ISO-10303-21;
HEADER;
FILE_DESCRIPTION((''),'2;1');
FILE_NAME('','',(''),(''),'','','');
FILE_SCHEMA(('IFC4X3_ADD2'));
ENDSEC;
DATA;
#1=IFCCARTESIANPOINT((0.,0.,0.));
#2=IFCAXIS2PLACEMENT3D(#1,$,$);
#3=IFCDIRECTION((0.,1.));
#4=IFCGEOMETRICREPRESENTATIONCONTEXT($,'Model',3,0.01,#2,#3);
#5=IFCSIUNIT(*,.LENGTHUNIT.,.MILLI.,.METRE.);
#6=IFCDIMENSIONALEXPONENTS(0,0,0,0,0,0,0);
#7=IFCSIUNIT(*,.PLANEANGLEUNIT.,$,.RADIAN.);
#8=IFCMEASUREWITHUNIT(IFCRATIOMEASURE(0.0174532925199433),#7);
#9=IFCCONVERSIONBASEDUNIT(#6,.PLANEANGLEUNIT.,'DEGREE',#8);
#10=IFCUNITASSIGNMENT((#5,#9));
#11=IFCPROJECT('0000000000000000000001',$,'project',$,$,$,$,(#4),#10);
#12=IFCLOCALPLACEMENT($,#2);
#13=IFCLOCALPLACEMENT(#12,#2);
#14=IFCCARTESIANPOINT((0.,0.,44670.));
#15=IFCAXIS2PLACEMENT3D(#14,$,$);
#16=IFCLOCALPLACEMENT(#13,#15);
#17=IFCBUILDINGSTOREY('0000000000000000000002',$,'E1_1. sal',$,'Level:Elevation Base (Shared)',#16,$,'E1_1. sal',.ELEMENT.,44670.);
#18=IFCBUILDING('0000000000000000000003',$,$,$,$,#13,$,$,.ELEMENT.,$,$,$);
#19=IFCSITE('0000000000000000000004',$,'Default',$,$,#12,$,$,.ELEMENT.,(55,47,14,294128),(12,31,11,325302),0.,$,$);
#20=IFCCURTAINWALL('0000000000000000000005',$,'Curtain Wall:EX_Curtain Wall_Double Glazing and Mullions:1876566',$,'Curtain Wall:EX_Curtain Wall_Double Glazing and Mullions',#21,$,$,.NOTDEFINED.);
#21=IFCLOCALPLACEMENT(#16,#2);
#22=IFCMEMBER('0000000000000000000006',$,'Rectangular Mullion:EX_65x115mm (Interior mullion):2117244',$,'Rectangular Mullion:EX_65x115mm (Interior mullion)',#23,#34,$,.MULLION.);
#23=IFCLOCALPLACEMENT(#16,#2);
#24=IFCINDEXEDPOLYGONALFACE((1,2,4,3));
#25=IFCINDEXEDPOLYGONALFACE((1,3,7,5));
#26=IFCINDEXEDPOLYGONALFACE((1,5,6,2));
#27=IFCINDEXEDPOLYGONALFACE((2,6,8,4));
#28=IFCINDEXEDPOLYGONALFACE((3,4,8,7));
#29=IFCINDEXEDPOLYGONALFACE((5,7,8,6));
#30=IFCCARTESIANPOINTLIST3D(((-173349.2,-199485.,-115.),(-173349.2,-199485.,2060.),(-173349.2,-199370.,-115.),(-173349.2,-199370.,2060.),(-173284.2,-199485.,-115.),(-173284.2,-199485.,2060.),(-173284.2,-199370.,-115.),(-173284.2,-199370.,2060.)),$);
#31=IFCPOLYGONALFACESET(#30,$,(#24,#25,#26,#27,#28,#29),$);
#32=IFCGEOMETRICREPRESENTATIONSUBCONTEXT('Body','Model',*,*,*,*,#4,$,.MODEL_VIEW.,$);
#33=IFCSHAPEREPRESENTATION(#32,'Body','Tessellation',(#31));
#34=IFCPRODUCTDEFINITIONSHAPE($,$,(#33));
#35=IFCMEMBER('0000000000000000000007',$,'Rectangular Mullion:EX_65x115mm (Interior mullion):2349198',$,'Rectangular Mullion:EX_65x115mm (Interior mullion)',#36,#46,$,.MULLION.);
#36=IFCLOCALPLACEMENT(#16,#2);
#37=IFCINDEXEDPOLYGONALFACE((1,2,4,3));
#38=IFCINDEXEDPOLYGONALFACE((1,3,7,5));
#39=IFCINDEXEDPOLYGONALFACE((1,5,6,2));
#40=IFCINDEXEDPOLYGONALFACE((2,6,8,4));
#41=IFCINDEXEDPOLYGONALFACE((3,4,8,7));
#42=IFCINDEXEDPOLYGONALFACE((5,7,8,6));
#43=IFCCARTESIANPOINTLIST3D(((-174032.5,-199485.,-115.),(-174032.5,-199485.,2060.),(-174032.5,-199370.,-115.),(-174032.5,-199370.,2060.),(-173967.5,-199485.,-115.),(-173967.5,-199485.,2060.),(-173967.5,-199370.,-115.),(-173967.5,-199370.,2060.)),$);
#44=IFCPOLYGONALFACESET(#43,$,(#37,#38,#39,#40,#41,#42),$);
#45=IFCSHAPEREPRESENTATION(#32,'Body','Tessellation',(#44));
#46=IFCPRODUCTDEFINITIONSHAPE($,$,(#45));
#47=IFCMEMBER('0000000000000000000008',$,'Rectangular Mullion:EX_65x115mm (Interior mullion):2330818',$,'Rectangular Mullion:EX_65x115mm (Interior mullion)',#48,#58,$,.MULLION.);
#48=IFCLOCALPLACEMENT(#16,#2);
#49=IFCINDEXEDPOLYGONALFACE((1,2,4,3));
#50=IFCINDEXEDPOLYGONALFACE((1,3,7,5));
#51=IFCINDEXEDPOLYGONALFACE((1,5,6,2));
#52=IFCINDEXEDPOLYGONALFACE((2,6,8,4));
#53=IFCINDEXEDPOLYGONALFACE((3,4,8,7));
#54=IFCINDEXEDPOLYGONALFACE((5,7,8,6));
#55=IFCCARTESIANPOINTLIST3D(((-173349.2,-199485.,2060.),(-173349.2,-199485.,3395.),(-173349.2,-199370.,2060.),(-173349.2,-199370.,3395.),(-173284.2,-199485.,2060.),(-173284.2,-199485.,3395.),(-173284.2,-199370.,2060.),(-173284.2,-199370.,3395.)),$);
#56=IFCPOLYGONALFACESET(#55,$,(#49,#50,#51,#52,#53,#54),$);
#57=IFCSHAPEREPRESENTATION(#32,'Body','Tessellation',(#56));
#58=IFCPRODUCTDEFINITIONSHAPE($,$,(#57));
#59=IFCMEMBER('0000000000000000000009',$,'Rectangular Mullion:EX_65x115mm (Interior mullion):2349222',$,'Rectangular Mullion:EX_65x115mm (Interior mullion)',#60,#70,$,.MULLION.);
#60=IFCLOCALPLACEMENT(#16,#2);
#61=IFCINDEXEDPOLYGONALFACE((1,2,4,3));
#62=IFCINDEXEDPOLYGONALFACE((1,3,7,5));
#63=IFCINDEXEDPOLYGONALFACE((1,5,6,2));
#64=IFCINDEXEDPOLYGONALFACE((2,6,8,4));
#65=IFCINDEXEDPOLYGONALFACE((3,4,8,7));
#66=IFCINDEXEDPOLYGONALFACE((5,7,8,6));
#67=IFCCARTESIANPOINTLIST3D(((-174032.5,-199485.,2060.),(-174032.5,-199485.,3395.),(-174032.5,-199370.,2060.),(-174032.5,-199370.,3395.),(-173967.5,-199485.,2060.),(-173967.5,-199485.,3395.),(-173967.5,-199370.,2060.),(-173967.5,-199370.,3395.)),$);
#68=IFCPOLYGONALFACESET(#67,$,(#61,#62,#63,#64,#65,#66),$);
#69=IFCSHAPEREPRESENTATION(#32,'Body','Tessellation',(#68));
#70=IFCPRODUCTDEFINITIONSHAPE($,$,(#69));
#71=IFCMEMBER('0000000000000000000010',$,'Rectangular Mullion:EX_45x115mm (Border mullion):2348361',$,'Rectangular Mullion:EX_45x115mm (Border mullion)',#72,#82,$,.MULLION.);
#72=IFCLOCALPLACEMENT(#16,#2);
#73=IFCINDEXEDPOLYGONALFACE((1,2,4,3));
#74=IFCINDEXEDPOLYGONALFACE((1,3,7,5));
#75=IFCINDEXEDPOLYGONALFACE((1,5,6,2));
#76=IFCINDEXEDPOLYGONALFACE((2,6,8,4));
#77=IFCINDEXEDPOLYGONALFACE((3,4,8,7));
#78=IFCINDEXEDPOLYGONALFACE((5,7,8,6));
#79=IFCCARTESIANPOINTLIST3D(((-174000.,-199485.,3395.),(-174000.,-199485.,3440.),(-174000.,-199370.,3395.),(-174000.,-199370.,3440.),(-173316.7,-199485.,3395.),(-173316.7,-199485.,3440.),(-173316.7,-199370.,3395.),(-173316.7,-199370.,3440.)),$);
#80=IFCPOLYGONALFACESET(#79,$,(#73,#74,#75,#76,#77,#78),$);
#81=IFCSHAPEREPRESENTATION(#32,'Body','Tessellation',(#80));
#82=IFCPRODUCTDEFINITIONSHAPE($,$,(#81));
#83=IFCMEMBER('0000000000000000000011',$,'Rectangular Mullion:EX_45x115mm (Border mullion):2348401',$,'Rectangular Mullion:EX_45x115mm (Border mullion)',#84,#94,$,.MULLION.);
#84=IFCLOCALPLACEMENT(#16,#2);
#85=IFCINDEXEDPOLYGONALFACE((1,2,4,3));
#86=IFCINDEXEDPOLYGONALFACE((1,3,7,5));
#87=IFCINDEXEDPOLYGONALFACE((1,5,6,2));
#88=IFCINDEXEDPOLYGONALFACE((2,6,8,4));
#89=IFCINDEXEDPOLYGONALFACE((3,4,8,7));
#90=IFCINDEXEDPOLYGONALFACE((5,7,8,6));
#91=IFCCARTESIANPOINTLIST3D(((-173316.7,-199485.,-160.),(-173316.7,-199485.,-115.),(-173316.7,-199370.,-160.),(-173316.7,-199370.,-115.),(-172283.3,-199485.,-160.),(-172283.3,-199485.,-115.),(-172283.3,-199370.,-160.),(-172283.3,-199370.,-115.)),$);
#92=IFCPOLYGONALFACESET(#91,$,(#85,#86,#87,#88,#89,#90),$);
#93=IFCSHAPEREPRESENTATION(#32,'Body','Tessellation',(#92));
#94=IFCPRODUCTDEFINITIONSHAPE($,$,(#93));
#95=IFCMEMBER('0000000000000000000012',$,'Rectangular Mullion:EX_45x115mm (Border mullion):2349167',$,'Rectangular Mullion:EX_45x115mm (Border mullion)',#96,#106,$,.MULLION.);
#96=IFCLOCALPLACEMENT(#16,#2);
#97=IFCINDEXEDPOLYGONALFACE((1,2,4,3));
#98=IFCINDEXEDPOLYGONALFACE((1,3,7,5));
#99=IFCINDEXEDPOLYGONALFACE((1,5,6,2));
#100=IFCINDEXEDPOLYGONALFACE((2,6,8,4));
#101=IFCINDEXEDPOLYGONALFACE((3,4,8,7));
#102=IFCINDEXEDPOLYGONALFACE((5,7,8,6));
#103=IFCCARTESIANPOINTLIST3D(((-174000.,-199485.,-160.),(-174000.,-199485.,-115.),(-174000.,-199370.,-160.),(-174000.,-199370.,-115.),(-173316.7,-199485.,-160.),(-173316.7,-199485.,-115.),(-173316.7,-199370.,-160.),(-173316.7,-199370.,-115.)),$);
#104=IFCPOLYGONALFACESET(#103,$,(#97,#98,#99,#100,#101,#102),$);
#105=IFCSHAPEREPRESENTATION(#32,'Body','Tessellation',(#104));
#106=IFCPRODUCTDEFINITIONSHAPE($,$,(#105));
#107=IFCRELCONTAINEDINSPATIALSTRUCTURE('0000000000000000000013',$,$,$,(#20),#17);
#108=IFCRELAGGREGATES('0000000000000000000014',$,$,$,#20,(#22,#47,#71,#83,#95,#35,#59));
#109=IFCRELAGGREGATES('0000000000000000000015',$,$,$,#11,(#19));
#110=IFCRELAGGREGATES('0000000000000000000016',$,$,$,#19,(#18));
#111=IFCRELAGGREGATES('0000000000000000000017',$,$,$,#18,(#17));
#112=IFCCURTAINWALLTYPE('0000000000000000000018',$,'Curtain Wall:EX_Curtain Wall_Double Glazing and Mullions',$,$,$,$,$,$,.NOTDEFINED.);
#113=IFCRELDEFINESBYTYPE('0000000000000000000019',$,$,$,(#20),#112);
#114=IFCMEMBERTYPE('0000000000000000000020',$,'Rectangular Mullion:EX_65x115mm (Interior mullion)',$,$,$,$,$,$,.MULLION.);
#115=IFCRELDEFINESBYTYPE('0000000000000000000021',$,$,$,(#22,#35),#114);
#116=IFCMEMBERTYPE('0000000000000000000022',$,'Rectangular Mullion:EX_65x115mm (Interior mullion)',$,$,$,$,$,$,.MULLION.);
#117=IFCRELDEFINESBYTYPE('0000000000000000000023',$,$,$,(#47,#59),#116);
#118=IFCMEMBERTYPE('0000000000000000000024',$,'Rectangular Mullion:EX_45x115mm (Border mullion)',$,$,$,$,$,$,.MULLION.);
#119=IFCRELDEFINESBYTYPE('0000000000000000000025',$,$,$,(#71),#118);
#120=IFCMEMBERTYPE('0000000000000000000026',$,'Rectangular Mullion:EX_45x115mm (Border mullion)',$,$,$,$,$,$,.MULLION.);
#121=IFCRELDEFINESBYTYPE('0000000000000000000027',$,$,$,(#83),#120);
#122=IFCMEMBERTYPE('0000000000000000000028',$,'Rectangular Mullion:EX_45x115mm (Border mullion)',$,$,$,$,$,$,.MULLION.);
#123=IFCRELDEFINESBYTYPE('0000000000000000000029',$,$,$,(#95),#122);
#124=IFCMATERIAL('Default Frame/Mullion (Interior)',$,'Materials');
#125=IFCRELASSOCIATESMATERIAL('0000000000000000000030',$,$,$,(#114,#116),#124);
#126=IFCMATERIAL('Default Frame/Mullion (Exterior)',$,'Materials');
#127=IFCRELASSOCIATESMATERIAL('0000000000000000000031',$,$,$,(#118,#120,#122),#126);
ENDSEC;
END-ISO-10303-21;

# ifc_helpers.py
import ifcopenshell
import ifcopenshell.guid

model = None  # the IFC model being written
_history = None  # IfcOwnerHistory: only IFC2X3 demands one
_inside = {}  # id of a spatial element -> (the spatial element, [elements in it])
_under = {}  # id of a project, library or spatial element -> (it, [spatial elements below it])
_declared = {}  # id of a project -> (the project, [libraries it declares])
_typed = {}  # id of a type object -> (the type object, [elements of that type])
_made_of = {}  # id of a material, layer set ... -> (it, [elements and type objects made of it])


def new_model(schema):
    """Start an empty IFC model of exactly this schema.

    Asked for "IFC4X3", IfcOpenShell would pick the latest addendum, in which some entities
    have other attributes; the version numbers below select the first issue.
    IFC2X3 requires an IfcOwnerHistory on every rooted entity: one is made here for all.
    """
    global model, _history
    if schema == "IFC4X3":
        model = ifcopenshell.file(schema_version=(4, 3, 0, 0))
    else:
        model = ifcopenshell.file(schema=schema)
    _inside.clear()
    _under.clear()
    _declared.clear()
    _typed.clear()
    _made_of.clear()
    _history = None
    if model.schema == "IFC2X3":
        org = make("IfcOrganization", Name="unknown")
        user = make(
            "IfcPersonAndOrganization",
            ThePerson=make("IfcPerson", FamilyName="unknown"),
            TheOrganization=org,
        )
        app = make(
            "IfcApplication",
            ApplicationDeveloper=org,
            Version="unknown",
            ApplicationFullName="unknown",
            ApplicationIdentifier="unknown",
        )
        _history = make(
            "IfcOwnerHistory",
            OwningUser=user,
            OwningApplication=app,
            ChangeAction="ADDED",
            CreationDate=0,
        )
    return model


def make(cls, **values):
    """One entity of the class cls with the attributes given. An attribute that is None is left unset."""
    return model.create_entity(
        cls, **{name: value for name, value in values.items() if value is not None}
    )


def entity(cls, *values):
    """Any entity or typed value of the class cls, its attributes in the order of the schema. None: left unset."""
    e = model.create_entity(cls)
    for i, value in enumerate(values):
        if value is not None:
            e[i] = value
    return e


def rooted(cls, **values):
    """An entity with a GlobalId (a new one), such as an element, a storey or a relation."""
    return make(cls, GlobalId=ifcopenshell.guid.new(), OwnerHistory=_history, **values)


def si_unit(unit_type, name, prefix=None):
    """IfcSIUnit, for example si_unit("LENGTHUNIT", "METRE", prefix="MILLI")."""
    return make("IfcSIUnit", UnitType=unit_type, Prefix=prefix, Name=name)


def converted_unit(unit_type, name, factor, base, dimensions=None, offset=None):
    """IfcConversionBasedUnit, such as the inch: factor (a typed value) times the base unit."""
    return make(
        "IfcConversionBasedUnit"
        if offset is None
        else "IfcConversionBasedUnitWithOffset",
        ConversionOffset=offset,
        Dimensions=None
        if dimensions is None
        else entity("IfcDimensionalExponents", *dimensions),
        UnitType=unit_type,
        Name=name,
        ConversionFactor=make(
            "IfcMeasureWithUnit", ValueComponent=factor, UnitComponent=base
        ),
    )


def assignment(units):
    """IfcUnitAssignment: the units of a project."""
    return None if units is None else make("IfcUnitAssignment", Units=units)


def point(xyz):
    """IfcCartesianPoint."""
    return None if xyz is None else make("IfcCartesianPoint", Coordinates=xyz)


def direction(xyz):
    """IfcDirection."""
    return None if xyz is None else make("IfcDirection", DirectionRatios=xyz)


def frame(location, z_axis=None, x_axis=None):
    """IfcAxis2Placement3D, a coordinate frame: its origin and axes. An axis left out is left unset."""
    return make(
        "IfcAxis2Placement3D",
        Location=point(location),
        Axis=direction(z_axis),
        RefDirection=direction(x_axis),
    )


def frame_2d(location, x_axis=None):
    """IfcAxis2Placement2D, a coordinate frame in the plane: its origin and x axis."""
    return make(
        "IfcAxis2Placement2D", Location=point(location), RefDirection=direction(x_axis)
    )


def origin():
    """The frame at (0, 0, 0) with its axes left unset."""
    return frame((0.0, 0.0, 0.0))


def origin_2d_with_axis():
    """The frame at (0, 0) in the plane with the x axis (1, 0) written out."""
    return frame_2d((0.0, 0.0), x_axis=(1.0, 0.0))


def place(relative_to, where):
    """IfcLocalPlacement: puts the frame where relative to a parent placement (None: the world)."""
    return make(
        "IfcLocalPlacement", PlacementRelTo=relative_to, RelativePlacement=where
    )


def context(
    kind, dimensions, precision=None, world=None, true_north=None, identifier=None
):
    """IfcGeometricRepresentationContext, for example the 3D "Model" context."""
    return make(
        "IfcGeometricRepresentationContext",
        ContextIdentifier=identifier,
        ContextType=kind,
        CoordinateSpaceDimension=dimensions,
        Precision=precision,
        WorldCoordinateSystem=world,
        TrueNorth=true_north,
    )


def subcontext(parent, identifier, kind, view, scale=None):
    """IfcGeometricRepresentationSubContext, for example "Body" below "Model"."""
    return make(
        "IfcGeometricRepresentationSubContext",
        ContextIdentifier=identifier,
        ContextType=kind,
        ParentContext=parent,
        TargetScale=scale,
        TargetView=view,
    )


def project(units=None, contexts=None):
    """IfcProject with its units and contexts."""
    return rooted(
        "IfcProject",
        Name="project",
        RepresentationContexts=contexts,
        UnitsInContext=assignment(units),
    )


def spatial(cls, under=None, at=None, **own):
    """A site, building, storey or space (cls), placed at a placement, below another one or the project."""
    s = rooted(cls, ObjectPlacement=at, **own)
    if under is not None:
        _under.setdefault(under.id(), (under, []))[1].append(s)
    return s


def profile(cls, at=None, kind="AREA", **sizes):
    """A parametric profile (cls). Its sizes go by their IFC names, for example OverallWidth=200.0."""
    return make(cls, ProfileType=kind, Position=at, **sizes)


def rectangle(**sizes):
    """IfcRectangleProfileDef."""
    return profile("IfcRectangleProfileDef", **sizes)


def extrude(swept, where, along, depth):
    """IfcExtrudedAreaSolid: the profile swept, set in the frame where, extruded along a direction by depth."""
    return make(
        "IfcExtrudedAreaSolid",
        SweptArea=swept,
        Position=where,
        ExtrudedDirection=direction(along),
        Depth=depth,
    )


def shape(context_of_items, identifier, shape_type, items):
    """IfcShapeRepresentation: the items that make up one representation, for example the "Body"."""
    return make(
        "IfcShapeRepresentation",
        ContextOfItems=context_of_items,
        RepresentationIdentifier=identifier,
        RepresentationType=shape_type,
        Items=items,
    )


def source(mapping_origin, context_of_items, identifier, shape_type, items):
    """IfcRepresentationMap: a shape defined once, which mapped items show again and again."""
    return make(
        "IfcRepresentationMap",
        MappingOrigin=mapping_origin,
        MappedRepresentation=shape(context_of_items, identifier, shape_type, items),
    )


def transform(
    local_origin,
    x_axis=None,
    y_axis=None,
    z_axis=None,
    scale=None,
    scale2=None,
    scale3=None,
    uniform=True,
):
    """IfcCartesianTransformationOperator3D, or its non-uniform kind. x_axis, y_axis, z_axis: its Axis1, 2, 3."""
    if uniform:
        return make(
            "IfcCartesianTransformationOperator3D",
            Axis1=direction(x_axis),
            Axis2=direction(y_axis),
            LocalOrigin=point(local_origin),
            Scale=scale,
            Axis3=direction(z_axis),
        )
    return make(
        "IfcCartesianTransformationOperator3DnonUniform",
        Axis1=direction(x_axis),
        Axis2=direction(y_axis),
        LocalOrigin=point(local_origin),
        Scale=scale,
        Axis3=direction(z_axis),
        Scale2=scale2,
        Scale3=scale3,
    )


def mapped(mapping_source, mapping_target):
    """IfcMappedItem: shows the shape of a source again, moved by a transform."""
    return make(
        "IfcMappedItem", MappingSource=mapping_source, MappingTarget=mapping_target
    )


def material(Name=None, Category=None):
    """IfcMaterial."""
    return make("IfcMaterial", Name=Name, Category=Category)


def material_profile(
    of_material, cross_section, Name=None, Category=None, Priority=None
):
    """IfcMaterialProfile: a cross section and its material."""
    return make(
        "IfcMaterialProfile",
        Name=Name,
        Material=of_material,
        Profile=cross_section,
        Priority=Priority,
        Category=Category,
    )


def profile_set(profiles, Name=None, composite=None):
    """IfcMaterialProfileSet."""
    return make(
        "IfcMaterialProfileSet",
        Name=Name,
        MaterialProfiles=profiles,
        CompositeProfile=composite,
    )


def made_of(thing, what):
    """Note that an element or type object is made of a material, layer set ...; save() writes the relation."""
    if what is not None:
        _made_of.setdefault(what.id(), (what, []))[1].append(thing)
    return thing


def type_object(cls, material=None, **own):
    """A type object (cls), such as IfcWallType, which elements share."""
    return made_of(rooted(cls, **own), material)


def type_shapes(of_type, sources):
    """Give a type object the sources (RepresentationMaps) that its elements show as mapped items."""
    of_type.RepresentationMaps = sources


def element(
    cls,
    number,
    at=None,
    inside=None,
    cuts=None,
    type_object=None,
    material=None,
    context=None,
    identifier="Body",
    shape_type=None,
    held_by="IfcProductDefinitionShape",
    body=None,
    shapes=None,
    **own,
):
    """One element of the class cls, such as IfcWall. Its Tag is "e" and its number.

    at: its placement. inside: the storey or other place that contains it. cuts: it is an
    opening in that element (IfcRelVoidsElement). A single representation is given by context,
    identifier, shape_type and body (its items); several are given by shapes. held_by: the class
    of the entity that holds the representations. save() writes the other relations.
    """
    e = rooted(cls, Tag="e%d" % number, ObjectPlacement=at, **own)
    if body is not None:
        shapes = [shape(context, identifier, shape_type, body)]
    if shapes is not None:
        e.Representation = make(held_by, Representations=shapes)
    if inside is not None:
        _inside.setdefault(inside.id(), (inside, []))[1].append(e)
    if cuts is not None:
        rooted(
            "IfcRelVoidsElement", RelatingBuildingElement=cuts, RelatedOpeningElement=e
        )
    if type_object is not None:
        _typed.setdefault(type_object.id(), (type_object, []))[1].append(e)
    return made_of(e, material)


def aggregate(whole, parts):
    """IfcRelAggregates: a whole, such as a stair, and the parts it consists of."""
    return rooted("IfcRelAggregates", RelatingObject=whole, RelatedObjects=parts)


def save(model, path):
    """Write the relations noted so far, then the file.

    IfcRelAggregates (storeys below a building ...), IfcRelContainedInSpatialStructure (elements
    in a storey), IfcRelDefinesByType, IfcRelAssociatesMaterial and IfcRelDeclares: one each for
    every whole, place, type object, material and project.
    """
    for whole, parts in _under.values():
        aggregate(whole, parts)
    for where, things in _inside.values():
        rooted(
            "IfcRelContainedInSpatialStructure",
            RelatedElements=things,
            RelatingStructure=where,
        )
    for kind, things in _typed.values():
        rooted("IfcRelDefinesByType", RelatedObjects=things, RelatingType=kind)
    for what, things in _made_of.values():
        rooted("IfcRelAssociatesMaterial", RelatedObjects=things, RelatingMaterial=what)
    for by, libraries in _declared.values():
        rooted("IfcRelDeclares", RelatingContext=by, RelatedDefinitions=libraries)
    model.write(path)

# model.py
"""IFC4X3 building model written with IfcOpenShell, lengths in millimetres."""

from ifc_helpers import new_model, entity, si_unit, converted_unit, direction, frame, origin, origin_2d_with_axis, place, context, subcontext, project, spatial, rectangle, extrude, source, transform, mapped, material, material_profile, profile_set, type_object, type_shapes, element, aggregate, save


model = new_model("IFC4X3")

# Units and contexts
model_context = context("Model", 3, precision=0.01, world=origin(), true_north=direction((0.0, 1.0)))
body_context = subcontext(model_context, "Body", "Model", "MODEL_VIEW")
ifc_project = project(units=[si_unit("LENGTHUNIT", "METRE", prefix="MILLI"), converted_unit("PLANEANGLEUNIT", "DEGREE", entity("IfcRatioMeasure", 0.0174532925199433), si_unit("PLANEANGLEUNIT", "RADIAN"), dimensions=[0, 0, 0, 0, 0, 0, 0])], contexts=[model_context])

# Site, building, storey
site_placement = place(None, origin())
site = spatial("IfcSite", under=ifc_project, at=site_placement, Name="Default", CompositionType="ELEMENT", RefLatitude=(55, 47, 14, 294128), RefLongitude=(12, 31, 11, 325302), RefElevation=0.0)
building_placement = place(site_placement, origin())
building = spatial("IfcBuilding", under=site, at=building_placement, CompositionType="ELEMENT")
storey_placement = place(building_placement, frame((0.0, 0.0, 44670.0)))
storey = spatial("IfcBuildingStorey", under=building, at=storey_placement, Name="E1_1. sal", ObjectType="Level:Elevation Base (Shared)", LongName="E1_1. sal", CompositionType="ELEMENT", Elevation=44670.0)

# Curtain wall, members
curtain_wall_type = type_object("IfcCurtainWallType", Name="Curtain Wall:EX_Curtain Wall_Double Glazing and Mullions", PredefinedType="NOTDEFINED")
curtain_wall_placement = place(storey_placement, frame((0.0, 0.0, -44670.0)))
curtain_wall = element("IfcCurtainWall", 1, at=curtain_wall_placement, inside=storey, type_object=curtain_wall_type, Name="Curtain Wall:EX_Curtain Wall_Double Glazing and Mullions:1876566", ObjectType="Curtain Wall:EX_Curtain Wall_Double Glazing and Mullions", PredefinedType="NOTDEFINED")
ifc_material_1 = material(Name="Default Frame/Mullion (Interior)", Category="Materials")
ifc_material_profile_1 = material_profile(ifc_material_1, rectangle(XDim=115.0, YDim=65.0, at=origin_2d_with_axis()), Name="EX_65x115mm (Interior mullion)")
ifc_profile_set_1 = profile_set([ifc_material_profile_1], Name="EX_65x115mm (Interior mullion)")
member_type_1 = type_object("IfcMemberType", Name="Rectangular Mullion:EX_65x115mm (Interior mullion)", PredefinedType="MULLION", material=ifc_profile_set_1)
shared_shape_1 = source(origin(), body_context, "Body", "SweptSolid", [
    extrude(rectangle(XDim=115.0, YDim=65.0, at=origin_2d_with_axis()), frame((0.0, -57.5, -2175.0), z_axis=(0.0, 0.0, 1.0), x_axis=(0.0, -1.0, 0.0)), (0.0, 0.0, 1.0), 2175.0),
])
type_shapes(member_type_1, [shared_shape_1])
member_1_placement = place(curtain_wall_placement, frame((-173316.7, -199485.0, 44555.0), z_axis=(0.0, 0.0, -1.0), x_axis=(1.0, 0.0, 0.0)))
member_1 = element("IfcMember", 2, at=member_1_placement, type_object=member_type_1, Name="Rectangular Mullion:EX_65x115mm (Interior mullion):2117244", ObjectType="Rectangular Mullion:EX_65x115mm (Interior mullion)", PredefinedType="MULLION", context=body_context, shape_type="MappedRepresentation", body=[
    mapped(shared_shape_1, transform((0.0, 0.0, 0.0), scale=1.0)),
])
member_2_placement = place(curtain_wall_placement, frame((-174000.0, -199485.0, 44555.0), z_axis=(0.0, 0.0, -1.0), x_axis=(1.0, 0.0, 0.0)))
member_2 = element("IfcMember", 3, at=member_2_placement, type_object=member_type_1, Name="Rectangular Mullion:EX_65x115mm (Interior mullion):2349198", ObjectType="Rectangular Mullion:EX_65x115mm (Interior mullion)", PredefinedType="MULLION", context=body_context, shape_type="MappedRepresentation", body=[
    mapped(shared_shape_1, transform((0.0, 0.0, 0.0), scale=1.0)),
])
member_type_2 = type_object("IfcMemberType", Name="Rectangular Mullion:EX_65x115mm (Interior mullion)", PredefinedType="MULLION", material=ifc_profile_set_1)
shared_shape_2 = source(origin(), body_context, "Body", "SweptSolid", [
    extrude(rectangle(XDim=115.0, YDim=65.0, at=origin_2d_with_axis()), frame((0.0, -57.5, -1335.0), z_axis=(0.0, 0.0, 1.0), x_axis=(0.0, -1.0, 0.0)), (0.0, 0.0, 1.0), 1335.0),
])
type_shapes(member_type_2, [shared_shape_2])
member_3_placement = place(curtain_wall_placement, frame((-173316.7, -199485.0, 46730.0), z_axis=(0.0, 0.0, -1.0), x_axis=(1.0, 0.0, 0.0)))
member_3 = element("IfcMember", 4, at=member_3_placement, type_object=member_type_2, Name="Rectangular Mullion:EX_65x115mm (Interior mullion):2330818", ObjectType="Rectangular Mullion:EX_65x115mm (Interior mullion)", PredefinedType="MULLION", context=body_context, shape_type="MappedRepresentation", body=[
    mapped(shared_shape_2, transform((0.0, 0.0, 0.0), scale=1.0)),
])
member_4_placement = place(curtain_wall_placement, frame((-174000.0, -199485.0, 46730.0), z_axis=(0.0, 0.0, -1.0), x_axis=(1.0, 0.0, 0.0)))
member_4 = element("IfcMember", 5, at=member_4_placement, type_object=member_type_2, Name="Rectangular Mullion:EX_65x115mm (Interior mullion):2349222", ObjectType="Rectangular Mullion:EX_65x115mm (Interior mullion)", PredefinedType="MULLION", context=body_context, shape_type="MappedRepresentation", body=[
    mapped(shared_shape_2, transform((0.0, 0.0, 0.0), scale=1.0)),
])
ifc_material_2 = material(Name="Default Frame/Mullion (Exterior)", Category="Materials")
ifc_material_profile_2 = material_profile(ifc_material_2, rectangle(XDim=115.0, YDim=45.0, at=origin_2d_with_axis()), Name="EX_45x115mm (Border mullion)")
ifc_profile_set_2 = profile_set([ifc_material_profile_2], Name="EX_45x115mm (Border mullion)")
member_type_3 = type_object("IfcMemberType", Name="Rectangular Mullion:EX_45x115mm (Border mullion)", PredefinedType="MULLION", material=ifc_profile_set_2)
shared_shape_3 = source(origin(), body_context, "Body", "SweptSolid", [
    extrude(rectangle(XDim=115.0, YDim=45.0, at=origin_2d_with_axis()), frame((-22.5, -57.5, -683.3), z_axis=(0.0, 0.0, 1.0), x_axis=(0.0, -1.0, 0.0)), (0.0, 0.0, 1.0), 683.3),
])
type_shapes(member_type_3, [shared_shape_3])
member_5_placement = place(curtain_wall_placement, frame((-173316.7, -199485.0, 48110.0), z_axis=(1.0, 0.0, 0.0), x_axis=(0.0, 0.0, 1.0)))
member_5 = element("IfcMember", 6, at=member_5_placement, type_object=member_type_3, Name="Rectangular Mullion:EX_45x115mm (Border mullion):2348361", ObjectType="Rectangular Mullion:EX_45x115mm (Border mullion)", PredefinedType="MULLION", context=body_context, shape_type="MappedRepresentation", body=[
    mapped(shared_shape_3, transform((0.0, 0.0, 0.0), scale=1.0)),
])
member_type_4 = type_object("IfcMemberType", Name="Rectangular Mullion:EX_45x115mm (Border mullion)", PredefinedType="MULLION", material=ifc_profile_set_2)
shared_shape_4 = source(origin(), body_context, "Body", "SweptSolid", [
    extrude(rectangle(XDim=115.0, YDim=45.0, at=origin_2d_with_axis()), frame((-22.5, -57.5, -1033.3), z_axis=(0.0, 0.0, 1.0), x_axis=(0.0, -1.0, 0.0)), (0.0, 0.0, 1.0), 1033.3),
])
type_shapes(member_type_4, [shared_shape_4])
member_6_placement = place(curtain_wall_placement, frame((-173316.7, -199485.0, 44510.0), z_axis=(-1.0, 0.0, 0.0), x_axis=(0.0, 0.0, -1.0)))
member_6 = element("IfcMember", 7, at=member_6_placement, type_object=member_type_4, Name="Rectangular Mullion:EX_45x115mm (Border mullion):2348401", ObjectType="Rectangular Mullion:EX_45x115mm (Border mullion)", PredefinedType="MULLION", context=body_context, shape_type="MappedRepresentation", body=[
    mapped(shared_shape_4, transform((0.0, 0.0, 0.0), scale=1.0)),
])
member_type_5 = type_object("IfcMemberType", Name="Rectangular Mullion:EX_45x115mm (Border mullion)", PredefinedType="MULLION", material=ifc_profile_set_2)
shared_shape_5 = source(origin(), body_context, "Body", "SweptSolid", [
    extrude(rectangle(XDim=115.0, YDim=45.0, at=origin_2d_with_axis()), frame((-22.5, -57.5, -683.3), z_axis=(0.0, 0.0, 1.0), x_axis=(0.0, -1.0, 0.0)), (0.0, 0.0, 1.0), 683.3),
])
type_shapes(member_type_5, [shared_shape_5])
member_7_placement = place(curtain_wall_placement, frame((-174000.0, -199485.0, 44510.0), z_axis=(-1.0, 0.0, 0.0), x_axis=(0.0, 0.0, -1.0)))
member_7 = element("IfcMember", 8, at=member_7_placement, type_object=member_type_5, Name="Rectangular Mullion:EX_45x115mm (Border mullion):2349167", ObjectType="Rectangular Mullion:EX_45x115mm (Border mullion)", PredefinedType="MULLION", context=body_context, shape_type="MappedRepresentation", body=[
    mapped(shared_shape_5, transform((0.0, 0.0, 0.0), scale=1.0)),
])
aggregate(curtain_wall, [member_1, member_3, member_5, member_6, member_7, member_2, member_4])

save(model, "model.ifc")
